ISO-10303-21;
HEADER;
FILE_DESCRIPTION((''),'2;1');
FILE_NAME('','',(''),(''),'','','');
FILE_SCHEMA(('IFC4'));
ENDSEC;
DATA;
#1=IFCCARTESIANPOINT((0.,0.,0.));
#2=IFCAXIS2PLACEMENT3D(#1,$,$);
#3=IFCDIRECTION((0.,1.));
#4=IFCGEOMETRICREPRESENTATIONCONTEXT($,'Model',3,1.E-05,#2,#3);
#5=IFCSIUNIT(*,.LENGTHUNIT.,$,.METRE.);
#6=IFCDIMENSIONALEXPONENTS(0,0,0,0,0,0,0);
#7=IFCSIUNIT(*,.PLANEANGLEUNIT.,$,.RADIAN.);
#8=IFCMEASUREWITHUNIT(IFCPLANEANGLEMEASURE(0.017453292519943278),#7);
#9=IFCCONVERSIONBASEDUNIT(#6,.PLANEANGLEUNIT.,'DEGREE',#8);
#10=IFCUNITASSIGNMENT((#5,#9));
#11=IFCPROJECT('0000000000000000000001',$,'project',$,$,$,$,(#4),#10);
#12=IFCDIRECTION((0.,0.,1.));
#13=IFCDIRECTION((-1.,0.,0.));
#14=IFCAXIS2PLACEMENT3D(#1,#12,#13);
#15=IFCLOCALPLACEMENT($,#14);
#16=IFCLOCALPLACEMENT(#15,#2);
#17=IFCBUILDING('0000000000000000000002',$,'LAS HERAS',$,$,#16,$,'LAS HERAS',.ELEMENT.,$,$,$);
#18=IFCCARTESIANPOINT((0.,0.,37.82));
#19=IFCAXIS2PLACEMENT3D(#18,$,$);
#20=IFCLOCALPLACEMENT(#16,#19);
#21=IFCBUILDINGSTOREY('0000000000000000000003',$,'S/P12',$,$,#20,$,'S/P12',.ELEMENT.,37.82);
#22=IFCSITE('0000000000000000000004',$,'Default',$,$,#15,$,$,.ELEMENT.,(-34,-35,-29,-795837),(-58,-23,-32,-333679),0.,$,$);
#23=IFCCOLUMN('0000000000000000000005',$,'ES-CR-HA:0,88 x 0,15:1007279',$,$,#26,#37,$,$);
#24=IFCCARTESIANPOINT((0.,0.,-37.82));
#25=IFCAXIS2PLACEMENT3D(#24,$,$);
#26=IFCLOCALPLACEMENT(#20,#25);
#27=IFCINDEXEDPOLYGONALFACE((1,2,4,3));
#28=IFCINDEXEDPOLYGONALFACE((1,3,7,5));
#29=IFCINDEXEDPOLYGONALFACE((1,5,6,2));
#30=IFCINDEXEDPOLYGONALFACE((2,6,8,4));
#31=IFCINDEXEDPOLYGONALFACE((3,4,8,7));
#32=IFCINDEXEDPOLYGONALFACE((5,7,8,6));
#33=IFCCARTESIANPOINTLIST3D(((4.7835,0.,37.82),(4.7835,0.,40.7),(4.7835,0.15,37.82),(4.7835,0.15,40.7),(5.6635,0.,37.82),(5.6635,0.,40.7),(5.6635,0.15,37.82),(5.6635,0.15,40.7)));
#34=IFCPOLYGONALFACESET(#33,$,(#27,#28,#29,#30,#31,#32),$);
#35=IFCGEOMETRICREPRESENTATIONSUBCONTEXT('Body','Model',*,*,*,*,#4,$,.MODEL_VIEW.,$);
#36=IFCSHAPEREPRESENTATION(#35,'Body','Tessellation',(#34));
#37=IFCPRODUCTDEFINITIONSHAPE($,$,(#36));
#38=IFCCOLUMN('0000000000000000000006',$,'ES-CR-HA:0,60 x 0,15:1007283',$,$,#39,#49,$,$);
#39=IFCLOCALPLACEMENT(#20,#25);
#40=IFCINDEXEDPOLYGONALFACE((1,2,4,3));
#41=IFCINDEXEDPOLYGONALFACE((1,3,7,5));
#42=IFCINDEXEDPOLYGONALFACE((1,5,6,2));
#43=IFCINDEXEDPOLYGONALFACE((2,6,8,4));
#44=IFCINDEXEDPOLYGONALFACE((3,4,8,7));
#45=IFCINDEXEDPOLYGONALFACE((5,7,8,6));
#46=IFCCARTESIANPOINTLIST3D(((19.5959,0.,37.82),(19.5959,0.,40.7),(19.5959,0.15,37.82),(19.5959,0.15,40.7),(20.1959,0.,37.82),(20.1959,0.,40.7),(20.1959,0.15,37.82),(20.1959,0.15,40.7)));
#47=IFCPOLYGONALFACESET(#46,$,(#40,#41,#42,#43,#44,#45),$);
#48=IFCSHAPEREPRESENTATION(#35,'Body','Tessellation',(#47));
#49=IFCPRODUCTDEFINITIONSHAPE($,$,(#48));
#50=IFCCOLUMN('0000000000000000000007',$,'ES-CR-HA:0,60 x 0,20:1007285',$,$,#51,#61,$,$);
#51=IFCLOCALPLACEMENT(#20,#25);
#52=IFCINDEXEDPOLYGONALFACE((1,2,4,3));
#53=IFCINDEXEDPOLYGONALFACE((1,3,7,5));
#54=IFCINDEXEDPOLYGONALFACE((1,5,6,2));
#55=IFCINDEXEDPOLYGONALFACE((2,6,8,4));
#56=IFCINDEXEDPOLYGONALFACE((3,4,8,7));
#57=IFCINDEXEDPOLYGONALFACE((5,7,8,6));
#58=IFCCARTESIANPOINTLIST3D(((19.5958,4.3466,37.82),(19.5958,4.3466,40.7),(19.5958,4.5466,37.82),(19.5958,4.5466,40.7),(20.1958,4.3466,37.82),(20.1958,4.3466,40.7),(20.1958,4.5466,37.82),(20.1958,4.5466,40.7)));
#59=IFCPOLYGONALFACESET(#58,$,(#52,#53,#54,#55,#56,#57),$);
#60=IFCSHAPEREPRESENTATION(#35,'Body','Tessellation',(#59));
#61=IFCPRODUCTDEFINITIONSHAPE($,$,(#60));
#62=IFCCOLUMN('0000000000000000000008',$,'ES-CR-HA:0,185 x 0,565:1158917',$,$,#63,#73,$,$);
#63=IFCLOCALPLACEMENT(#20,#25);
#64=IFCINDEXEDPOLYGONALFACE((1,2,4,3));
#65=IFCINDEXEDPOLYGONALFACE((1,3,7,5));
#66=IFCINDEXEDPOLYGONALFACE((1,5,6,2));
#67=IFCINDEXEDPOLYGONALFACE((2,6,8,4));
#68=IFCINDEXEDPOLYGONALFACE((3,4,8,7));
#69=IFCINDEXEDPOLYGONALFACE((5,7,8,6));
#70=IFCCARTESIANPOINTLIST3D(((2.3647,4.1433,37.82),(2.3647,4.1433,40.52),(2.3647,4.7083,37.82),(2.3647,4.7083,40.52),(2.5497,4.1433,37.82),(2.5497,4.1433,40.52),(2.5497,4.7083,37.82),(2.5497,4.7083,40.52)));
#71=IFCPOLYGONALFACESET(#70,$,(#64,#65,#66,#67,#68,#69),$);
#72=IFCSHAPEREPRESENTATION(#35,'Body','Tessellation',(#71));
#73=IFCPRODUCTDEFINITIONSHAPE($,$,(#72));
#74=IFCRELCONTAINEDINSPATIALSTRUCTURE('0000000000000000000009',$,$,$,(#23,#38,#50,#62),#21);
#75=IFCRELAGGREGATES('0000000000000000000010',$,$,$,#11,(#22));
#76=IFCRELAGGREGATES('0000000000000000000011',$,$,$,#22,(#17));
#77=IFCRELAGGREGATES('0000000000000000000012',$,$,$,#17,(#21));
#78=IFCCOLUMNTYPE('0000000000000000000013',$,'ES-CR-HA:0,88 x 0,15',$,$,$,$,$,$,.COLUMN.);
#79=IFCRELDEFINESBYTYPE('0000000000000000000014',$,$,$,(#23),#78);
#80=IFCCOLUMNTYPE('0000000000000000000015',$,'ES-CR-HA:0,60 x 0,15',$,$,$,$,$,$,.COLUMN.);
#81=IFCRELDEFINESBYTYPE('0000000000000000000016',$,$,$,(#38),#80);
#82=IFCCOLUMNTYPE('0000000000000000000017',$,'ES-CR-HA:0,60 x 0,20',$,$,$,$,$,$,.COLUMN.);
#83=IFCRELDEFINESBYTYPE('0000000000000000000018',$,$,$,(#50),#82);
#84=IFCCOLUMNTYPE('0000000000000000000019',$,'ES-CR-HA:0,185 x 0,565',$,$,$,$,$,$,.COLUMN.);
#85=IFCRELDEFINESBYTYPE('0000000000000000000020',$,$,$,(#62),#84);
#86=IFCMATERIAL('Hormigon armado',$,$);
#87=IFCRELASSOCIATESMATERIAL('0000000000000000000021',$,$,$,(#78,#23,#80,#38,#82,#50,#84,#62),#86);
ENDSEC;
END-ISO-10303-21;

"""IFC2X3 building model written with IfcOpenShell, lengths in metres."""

from ifc_helpers import new_model, entity, si_unit, converted_unit, direction, frame, frame_2d, origin, place, context, subcontext, project, spatial, rectangle, extrude, source, transform, mapped, material, type_object, type_shapes, element, save


model = new_model("IFC2X3")

# Units and contexts
model_context = context("Model", 3, precision=1e-05, world=origin(), true_north=direction((0.0, 1.0)))
body_context = subcontext(model_context, "Body", "Model", "MODEL_VIEW")
ifc_project = project(units=[si_unit("LENGTHUNIT", "METRE"), converted_unit("PLANEANGLEUNIT", "DEGREE", entity("IfcPlaneAngleMeasure", 0.017453292519943278), si_unit("PLANEANGLEUNIT", "RADIAN"), dimensions=[0, 0, 0, 0, 0, 0, 0])], contexts=[model_context])

# Site, building, storey
site_placement = place(None, frame((0.0, 0.0, 0.0), z_axis=(0.0, 0.0, 1.0), x_axis=(-1.0, 0.0, 0.0)))
site = spatial("IfcSite", under=ifc_project, at=site_placement, Name="Default", CompositionType="ELEMENT", RefLatitude=(-34, -35, -29, -795837), RefLongitude=(-58, -23, -32, -333679), RefElevation=0.0)
building_placement = place(site_placement, origin())
building = spatial("IfcBuilding", under=site, at=building_placement, Name="LAS HERAS", LongName="LAS HERAS", CompositionType="ELEMENT")
storey_placement = place(building_placement, frame((0.0, 0.0, 37.82)))
storey = spatial("IfcBuildingStorey", under=building, at=storey_placement, Name="S/P12", LongName="S/P12", CompositionType="ELEMENT", Elevation=37.82)

# Columns
ifc_material = material(Name="Hormigon armado")
column_type_1 = type_object("IfcColumnType", Name="ES-CR-HA:0,88 x 0,15", PredefinedType="COLUMN", material=ifc_material)
shared_shape_1 = source(origin(), body_context, "Body", "SweptSolid", [
    extrude(rectangle(XDim=0.15, YDim=0.88, at=frame_2d((0.0, 0.0), x_axis=(1.0, 0.0))), frame((5.2235, 0.075, 37.82), z_axis=(0.0, 0.0, 1.0), x_axis=(0.0, 1.0, 0.0)), (0.0, 0.0, 1.0), 2.88),
])
type_shapes(column_type_1, [shared_shape_1])
column_1_placement = place(storey_placement, frame((0.0, 0.0, -37.82)))
element("IfcColumn", 1, at=column_1_placement, inside=storey, type_object=column_type_1, material=ifc_material, Name="ES-CR-HA:0,88 x 0,15:1007279", context=body_context, shape_type="MappedRepresentation", body=[
    mapped(shared_shape_1, transform((0.0, 0.0, 0.0), scale=1.0)),
])
column_type_2 = type_object("IfcColumnType", Name="ES-CR-HA:0,60 x 0,15", PredefinedType="COLUMN", material=ifc_material)
shared_shape_2 = source(origin(), body_context, "Body", "SweptSolid", [
    extrude(rectangle(XDim=0.6, YDim=0.15, at=frame_2d((0.0, 0.0), x_axis=(1.0, 0.0))), frame((19.8959, 0.075, 37.82), z_axis=(0.0, 0.0, 1.0), x_axis=(-1.0, 0.0, 0.0)), (0.0, 0.0, 1.0), 2.88),
])
type_shapes(column_type_2, [shared_shape_2])
column_2_placement = place(storey_placement, frame((0.0, 0.0, -37.82)))
element("IfcColumn", 2, at=column_2_placement, inside=storey, type_object=column_type_2, material=ifc_material, Name="ES-CR-HA:0,60 x 0,15:1007283", context=body_context, shape_type="MappedRepresentation", body=[
    mapped(shared_shape_2, transform((0.0, 0.0, 0.0), scale=1.0)),
])
column_type_3 = type_object("IfcColumnType", Name="ES-CR-HA:0,60 x 0,20", PredefinedType="COLUMN", material=ifc_material)
shared_shape_3 = source(origin(), body_context, "Body", "SweptSolid", [
    extrude(rectangle(XDim=0.6, YDim=0.2, at=frame_2d((0.0, 0.0), x_axis=(1.0, 0.0))), frame((19.8958, 4.4466, 37.82), z_axis=(0.0, 0.0, 1.0), x_axis=(-1.0, 0.0, 0.0)), (0.0, 0.0, 1.0), 2.88),
])
type_shapes(column_type_3, [shared_shape_3])
column_3_placement = place(storey_placement, frame((0.0, 0.0, -37.82)))
element("IfcColumn", 3, at=column_3_placement, inside=storey, type_object=column_type_3, material=ifc_material, Name="ES-CR-HA:0,60 x 0,20:1007285", context=body_context, shape_type="MappedRepresentation", body=[
    mapped(shared_shape_3, transform((0.0, 0.0, 0.0), scale=1.0)),
])
column_type_4 = type_object("IfcColumnType", Name="ES-CR-HA:0,185 x 0,565", PredefinedType="COLUMN", material=ifc_material)
shared_shape_4 = source(origin(), body_context, "Body", "SweptSolid", [
    extrude(rectangle(XDim=2.7, YDim=0.565, at=frame_2d((0.0, 0.0), x_axis=(1.0, 0.0))), frame((2.3647, 4.4258, 39.17), z_axis=(1.0, 0.0, 0.0), x_axis=(0.0, 0.0, 1.0)), (0.0, 0.0, 1.0), 0.185),
])
type_shapes(column_type_4, [shared_shape_4])
column_4_placement = place(storey_placement, frame((0.0, 0.0, -37.82)))
element("IfcColumn", 4, at=column_4_placement, inside=storey, type_object=column_type_4, material=ifc_material, Name="ES-CR-HA:0,185 x 0,565:1158917", context=body_context, shape_type="MappedRepresentation", body=[
    mapped(shared_shape_4, transform((0.0, 0.0, 0.0), scale=1.0)),
])

save(model, "model.ifc")
